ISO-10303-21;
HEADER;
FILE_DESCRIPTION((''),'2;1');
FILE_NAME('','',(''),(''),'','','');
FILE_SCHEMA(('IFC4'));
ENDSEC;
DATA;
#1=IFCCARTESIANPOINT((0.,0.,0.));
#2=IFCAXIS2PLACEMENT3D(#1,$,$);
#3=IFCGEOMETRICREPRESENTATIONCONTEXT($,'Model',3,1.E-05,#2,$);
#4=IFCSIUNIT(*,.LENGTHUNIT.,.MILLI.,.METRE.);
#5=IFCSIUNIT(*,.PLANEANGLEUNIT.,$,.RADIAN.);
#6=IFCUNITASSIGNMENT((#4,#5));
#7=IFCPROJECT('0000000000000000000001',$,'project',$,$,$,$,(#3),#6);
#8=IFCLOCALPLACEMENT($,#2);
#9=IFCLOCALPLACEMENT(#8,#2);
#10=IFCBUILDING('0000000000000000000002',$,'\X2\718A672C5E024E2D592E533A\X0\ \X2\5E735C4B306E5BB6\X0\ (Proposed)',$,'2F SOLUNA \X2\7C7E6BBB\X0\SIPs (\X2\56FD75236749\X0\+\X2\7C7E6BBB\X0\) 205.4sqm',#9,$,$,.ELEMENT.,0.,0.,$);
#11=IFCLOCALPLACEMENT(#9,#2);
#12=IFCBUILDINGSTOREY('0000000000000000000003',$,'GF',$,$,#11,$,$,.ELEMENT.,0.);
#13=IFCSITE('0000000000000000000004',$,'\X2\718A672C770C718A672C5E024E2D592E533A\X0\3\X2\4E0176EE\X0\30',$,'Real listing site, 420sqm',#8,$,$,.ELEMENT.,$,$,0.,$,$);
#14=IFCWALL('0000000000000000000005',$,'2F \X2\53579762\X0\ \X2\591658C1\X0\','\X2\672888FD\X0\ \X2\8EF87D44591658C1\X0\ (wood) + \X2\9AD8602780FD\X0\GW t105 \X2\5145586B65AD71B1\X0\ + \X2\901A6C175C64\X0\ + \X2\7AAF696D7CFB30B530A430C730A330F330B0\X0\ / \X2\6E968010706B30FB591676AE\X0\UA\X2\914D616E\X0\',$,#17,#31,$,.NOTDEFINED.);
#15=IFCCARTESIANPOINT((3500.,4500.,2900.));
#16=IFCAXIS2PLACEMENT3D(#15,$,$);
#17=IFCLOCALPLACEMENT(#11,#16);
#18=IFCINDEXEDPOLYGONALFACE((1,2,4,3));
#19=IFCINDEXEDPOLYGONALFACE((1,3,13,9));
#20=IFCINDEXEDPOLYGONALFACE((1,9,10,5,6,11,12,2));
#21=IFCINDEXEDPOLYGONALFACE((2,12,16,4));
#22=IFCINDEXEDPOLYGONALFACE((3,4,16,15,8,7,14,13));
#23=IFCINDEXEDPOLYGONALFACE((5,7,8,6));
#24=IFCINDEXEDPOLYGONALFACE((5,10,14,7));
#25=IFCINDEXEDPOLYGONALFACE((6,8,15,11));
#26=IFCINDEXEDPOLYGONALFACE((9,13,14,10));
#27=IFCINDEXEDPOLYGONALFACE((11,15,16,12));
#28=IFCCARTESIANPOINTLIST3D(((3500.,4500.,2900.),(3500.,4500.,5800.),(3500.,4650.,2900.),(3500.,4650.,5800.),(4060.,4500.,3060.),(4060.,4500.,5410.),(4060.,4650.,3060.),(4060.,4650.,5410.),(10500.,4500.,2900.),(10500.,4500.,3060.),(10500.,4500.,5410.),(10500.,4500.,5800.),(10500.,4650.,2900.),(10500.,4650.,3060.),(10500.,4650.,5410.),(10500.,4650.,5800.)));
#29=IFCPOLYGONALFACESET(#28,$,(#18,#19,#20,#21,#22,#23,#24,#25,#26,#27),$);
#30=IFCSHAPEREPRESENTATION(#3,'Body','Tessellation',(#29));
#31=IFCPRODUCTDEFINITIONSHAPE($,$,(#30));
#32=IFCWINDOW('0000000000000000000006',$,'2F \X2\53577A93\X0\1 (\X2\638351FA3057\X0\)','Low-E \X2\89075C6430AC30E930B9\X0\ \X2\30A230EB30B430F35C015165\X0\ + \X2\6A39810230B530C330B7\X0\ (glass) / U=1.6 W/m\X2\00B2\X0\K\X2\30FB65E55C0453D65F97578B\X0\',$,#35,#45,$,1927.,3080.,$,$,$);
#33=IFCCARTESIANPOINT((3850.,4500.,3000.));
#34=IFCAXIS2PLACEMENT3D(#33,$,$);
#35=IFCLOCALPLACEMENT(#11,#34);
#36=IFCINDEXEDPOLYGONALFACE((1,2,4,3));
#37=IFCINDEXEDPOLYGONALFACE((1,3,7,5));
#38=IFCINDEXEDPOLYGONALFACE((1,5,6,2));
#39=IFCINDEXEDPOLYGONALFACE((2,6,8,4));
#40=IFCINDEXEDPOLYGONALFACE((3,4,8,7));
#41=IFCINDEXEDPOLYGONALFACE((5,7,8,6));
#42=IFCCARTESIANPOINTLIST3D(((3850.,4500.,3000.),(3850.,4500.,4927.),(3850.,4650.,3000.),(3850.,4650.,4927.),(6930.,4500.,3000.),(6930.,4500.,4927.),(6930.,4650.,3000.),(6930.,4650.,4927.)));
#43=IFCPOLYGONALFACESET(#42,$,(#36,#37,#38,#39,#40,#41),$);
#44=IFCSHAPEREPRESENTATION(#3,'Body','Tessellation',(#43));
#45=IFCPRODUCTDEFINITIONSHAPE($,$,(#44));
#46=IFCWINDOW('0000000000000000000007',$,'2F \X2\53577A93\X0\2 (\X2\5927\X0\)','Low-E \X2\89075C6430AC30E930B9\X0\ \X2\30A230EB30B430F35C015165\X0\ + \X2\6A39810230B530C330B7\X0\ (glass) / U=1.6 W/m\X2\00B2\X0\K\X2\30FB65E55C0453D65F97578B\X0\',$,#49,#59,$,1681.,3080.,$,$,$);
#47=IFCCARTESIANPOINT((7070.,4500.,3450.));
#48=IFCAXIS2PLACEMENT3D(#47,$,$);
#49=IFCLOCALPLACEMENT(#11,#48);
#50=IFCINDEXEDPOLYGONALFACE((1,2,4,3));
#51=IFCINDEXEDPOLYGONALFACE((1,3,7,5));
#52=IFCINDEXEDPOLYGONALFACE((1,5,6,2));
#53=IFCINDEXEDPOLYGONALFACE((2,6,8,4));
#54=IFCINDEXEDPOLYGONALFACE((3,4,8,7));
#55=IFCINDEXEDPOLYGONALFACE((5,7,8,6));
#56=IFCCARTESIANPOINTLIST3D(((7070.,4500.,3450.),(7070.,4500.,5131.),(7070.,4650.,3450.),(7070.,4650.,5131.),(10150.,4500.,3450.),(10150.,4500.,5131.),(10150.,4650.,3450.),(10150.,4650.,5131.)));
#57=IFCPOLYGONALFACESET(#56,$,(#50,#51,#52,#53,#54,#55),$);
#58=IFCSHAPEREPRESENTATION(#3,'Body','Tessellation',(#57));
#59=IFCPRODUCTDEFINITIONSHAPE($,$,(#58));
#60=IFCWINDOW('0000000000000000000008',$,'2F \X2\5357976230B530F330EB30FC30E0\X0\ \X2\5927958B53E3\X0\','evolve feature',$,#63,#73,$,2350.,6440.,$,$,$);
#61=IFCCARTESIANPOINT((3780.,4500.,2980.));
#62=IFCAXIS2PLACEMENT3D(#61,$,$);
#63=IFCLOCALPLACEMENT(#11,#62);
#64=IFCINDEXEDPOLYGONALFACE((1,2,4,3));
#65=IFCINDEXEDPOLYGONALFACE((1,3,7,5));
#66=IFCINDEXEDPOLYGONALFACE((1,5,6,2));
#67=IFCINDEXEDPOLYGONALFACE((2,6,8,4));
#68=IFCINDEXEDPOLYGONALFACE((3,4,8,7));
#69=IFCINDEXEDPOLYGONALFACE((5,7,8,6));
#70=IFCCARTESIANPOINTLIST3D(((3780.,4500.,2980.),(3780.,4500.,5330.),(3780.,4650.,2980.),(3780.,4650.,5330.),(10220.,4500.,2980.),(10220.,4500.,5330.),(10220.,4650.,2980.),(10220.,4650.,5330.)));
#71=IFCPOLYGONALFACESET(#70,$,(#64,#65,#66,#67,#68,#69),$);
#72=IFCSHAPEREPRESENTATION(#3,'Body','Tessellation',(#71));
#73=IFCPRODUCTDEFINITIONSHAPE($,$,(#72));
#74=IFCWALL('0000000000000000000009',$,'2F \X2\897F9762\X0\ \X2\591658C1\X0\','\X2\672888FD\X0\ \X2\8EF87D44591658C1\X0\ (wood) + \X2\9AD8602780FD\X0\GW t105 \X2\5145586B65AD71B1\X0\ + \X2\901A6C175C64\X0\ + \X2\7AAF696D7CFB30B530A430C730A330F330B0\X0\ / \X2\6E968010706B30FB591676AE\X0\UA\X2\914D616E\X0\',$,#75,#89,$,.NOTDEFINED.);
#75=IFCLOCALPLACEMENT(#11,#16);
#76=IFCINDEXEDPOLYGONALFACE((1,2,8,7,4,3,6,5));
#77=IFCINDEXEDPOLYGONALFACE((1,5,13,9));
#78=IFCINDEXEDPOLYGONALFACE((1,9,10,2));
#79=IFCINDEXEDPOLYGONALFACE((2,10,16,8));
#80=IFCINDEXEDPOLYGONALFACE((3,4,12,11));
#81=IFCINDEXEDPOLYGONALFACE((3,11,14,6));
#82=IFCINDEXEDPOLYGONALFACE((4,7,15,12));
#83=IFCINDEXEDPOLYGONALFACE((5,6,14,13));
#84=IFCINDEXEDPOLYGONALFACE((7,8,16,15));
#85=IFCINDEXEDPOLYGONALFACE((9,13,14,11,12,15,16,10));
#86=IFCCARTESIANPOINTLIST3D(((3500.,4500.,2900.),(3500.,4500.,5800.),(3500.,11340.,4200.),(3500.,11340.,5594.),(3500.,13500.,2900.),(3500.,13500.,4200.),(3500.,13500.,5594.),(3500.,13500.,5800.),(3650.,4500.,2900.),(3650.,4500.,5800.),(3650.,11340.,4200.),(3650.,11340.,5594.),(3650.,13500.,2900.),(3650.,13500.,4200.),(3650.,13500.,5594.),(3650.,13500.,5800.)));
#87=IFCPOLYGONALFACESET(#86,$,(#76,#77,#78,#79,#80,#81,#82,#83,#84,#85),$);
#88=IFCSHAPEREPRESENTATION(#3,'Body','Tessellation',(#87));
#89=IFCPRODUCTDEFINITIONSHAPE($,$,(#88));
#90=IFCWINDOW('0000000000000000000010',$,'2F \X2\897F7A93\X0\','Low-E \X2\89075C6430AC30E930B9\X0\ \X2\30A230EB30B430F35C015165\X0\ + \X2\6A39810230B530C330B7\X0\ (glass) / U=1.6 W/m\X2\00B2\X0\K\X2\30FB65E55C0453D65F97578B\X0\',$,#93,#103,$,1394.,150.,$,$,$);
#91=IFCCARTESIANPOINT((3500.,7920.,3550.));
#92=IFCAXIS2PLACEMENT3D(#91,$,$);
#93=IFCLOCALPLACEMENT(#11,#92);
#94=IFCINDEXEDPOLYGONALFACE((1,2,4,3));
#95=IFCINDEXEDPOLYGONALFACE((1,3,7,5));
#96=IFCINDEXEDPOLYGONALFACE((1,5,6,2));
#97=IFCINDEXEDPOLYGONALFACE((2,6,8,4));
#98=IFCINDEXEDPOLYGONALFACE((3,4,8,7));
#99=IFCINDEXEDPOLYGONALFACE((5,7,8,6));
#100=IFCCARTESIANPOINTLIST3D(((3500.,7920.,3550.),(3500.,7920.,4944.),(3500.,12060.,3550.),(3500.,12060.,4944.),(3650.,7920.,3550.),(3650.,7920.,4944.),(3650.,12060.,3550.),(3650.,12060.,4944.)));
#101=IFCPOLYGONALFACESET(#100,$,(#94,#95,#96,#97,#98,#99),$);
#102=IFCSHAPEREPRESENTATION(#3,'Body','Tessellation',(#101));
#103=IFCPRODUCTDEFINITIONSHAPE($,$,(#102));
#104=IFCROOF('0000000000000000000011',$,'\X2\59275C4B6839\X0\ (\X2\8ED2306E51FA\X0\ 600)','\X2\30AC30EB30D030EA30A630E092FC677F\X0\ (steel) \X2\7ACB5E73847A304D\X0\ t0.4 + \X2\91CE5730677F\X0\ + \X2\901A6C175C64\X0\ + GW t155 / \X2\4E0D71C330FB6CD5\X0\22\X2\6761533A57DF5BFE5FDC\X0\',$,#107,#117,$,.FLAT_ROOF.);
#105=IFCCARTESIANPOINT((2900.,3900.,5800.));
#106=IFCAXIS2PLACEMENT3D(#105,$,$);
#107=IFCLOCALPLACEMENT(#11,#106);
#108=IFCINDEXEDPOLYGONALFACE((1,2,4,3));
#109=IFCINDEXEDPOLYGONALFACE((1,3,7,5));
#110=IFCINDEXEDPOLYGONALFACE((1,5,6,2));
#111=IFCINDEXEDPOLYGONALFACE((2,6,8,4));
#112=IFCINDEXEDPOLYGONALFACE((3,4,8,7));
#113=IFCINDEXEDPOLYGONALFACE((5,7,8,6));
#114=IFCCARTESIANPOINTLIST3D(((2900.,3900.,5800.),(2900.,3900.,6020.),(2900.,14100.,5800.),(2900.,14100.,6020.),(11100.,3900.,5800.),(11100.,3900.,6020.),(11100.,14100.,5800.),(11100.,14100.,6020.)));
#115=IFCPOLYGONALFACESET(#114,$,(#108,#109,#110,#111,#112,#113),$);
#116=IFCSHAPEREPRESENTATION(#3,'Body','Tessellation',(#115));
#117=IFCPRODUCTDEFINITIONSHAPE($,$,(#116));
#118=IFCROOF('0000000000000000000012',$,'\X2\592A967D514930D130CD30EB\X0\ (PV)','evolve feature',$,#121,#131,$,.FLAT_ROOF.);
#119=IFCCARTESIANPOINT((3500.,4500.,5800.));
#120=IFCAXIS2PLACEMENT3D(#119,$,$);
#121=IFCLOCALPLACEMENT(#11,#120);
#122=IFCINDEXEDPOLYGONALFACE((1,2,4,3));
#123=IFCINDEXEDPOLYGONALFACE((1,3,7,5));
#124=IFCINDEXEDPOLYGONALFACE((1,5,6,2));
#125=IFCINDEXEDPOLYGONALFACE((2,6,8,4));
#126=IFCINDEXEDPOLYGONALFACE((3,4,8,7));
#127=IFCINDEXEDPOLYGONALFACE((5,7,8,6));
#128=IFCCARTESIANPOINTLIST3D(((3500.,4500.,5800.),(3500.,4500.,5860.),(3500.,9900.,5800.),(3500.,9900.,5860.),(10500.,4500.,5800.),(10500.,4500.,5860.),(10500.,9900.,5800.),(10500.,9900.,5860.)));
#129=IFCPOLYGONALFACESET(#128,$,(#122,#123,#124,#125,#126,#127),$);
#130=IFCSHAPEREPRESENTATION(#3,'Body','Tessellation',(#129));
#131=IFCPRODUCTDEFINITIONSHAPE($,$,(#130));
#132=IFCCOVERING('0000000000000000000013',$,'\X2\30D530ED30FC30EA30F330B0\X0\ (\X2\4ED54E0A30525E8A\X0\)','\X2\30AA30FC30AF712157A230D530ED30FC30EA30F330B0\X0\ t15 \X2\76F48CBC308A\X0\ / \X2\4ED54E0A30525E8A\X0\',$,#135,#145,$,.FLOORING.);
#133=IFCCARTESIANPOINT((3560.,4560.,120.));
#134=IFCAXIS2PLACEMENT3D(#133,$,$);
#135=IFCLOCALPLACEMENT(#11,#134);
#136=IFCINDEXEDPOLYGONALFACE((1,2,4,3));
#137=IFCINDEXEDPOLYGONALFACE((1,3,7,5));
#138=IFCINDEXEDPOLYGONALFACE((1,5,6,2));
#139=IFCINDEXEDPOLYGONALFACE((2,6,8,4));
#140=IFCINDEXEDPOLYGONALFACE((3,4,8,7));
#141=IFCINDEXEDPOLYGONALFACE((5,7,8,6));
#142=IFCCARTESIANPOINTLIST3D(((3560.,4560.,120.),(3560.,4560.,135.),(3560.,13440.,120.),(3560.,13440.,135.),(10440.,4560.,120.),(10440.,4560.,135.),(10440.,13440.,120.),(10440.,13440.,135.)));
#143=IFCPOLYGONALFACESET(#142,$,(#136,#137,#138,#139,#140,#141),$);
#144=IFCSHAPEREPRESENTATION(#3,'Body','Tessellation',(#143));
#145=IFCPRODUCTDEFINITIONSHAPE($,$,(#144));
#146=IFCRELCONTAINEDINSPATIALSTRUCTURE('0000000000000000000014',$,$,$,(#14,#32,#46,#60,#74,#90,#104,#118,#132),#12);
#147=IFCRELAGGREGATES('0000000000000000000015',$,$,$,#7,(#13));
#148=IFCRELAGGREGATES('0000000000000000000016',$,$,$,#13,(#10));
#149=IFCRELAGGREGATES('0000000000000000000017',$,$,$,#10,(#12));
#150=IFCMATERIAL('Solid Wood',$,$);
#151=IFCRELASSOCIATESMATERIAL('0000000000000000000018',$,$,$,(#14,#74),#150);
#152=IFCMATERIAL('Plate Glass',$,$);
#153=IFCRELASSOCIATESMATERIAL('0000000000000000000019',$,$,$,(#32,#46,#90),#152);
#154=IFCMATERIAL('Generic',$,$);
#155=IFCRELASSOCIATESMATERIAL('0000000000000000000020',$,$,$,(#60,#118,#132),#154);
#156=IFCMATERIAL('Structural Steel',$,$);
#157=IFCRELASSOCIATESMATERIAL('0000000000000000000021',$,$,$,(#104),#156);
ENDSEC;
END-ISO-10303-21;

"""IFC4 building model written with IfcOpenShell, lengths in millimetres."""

from ifc_helpers import new_model, si_unit, frame, frame_2d, origin, place, context, project, spatial, rectangle, extrude, material, element, fill, save


model = new_model("IFC4")

# Units and contexts
model_context = context("Model", 3, precision=1e-05, world=origin())
ifc_project = project(units=[si_unit("LENGTHUNIT", "METRE", prefix="MILLI"), si_unit("PLANEANGLEUNIT", "RADIAN")], contexts=[model_context])

# Site, building, storey
site_placement = place(None, origin())
site = spatial("IfcSite", under=ifc_project, at=site_placement, Name="熊本県熊本市中央区3丁目30", ObjectType="Real listing site, 420sqm", CompositionType="ELEMENT", RefElevation=0.0)
building_placement = place(site_placement, origin())
building = spatial("IfcBuilding", under=site, at=building_placement, Name="熊本市中央区 平屋の家 (Proposed)", ObjectType="2F SOLUNA 籾殻SIPs (国産杉+籾殻) 205.4sqm", CompositionType="ELEMENT", ElevationOfRefHeight=0.0, ElevationOfTerrain=0.0)
storey_placement = place(building_placement, origin())
storey = spatial("IfcBuildingStorey", under=building, at=storey_placement, Name="GF", CompositionType="ELEMENT", Elevation=0.0)

# Shared definitions
ifc_material_1 = material(Name="Solid Wood")

# Shared definitions
ifc_material_2 = material(Name="Plate Glass")
ifc_material_3 = material(Name="Generic")

# Wall, openings, windows
wall_1_placement = place(storey_placement, frame((3500.0, 4500.0, 2900.0)))
wall_1 = element("IfcWall", 1, at=wall_1_placement, inside=storey, material=ifc_material_1, Name="2F 南面 外壁", Description="木製 軸組外壁 (wood) + 高性能GW t105 充填断熱 + 通気層 + 窯業系サイディング / 準耐火・外皮UA配慮", PredefinedType="NOTDEFINED", context=model_context, shape_type="SweptSolid", body=[
    extrude(rectangle(XDim=7000.0, YDim=150.0, at=frame_2d((3500.0, 75.0))), frame((3500.0, 4500.0, 2900.0)), (0.0, 0.0, 1.0), 2900.0),
])
opening_1_placement = place(storey_placement, frame((3850.0, 4500.0, 3000.0)))
opening_1 = element("IfcOpeningElement", 2, at=opening_1_placement, cuts=wall_1, PredefinedType="NOTDEFINED", context=model_context, shape_type="SweptSolid", body=[
    extrude(rectangle(XDim=3080.0, YDim=150.0, at=frame_2d((1540.0, 75.0))), frame((3850.0, 4500.0, 3000.0)), (0.0, 0.0, 1.0), 1927.0),
])
opening_2_placement = place(storey_placement, frame((7070.0, 4500.0, 3450.0)))
opening_2 = element("IfcOpeningElement", 3, at=opening_2_placement, cuts=wall_1, PredefinedType="NOTDEFINED", context=model_context, shape_type="SweptSolid", body=[
    extrude(rectangle(XDim=3080.0, YDim=150.0, at=frame_2d((1540.0, 75.0))), frame((7070.0, 4500.0, 3450.0)), (0.0, 0.0, 1.0), 1681.0),
])
opening_3_placement = place(storey_placement, frame((3780.0, 4500.0, 2980.0)))
opening_3 = element("IfcOpeningElement", 4, at=opening_3_placement, cuts=wall_1, PredefinedType="NOTDEFINED", context=model_context, shape_type="SweptSolid", body=[
    extrude(rectangle(XDim=6440.0, YDim=150.0, at=frame_2d((3220.0, 75.0))), frame((3780.0, 4500.0, 2980.0)), (0.0, 0.0, 1.0), 2350.0),
])
window_1_placement = place(storey_placement, frame((3850.0, 4500.0, 3000.0)))
window_1 = element("IfcWindow", 5, at=window_1_placement, inside=storey, material=ifc_material_2, Name="2F 南窓1 (掃出し)", Description="Low-E 複層ガラス アルゴン封入 + 樹脂サッシ (glass) / U=1.6 W/m²K・日射取得型", OverallHeight=1927.0, OverallWidth=3080.0, context=model_context, shape_type="SweptSolid", body=[
    extrude(rectangle(XDim=3080.0, YDim=150.0, at=frame_2d((1540.0, 75.0))), frame((3850.0, 4500.0, 3000.0)), (0.0, 0.0, 1.0), 1927.0),
])
fill(opening_1, window_1)
window_2_placement = place(storey_placement, frame((7070.0, 4500.0, 3450.0)))
window_2 = element("IfcWindow", 6, at=window_2_placement, inside=storey, material=ifc_material_2, Name="2F 南窓2 (大)", Description="Low-E 複層ガラス アルゴン封入 + 樹脂サッシ (glass) / U=1.6 W/m²K・日射取得型", OverallHeight=1681.0, OverallWidth=3080.0, context=model_context, shape_type="SweptSolid", body=[
    extrude(rectangle(XDim=3080.0, YDim=150.0, at=frame_2d((1540.0, 75.0))), frame((7070.0, 4500.0, 3450.0)), (0.0, 0.0, 1.0), 1681.0),
])
fill(opening_2, window_2)
window_3_placement = place(storey_placement, frame((3780.0, 4500.0, 2980.0)))
window_3 = element("IfcWindow", 7, at=window_3_placement, inside=storey, material=ifc_material_3, Name="2F 南面サンルーム 大開口", Description="evolve feature", OverallHeight=2350.0, OverallWidth=6440.0, context=model_context, shape_type="SweptSolid", body=[
    extrude(rectangle(XDim=6440.0, YDim=150.0, at=frame_2d((3220.0, 75.0))), frame((3780.0, 4500.0, 2980.0)), (0.0, 0.0, 1.0), 2350.0),
])
fill(opening_3, window_3)

# Wall, opening, window
wall_2_placement = place(storey_placement, frame((3500.0, 4500.0, 2900.0)))
wall_2 = element("IfcWall", 8, at=wall_2_placement, inside=storey, material=ifc_material_1, Name="2F 西面 外壁", Description="木製 軸組外壁 (wood) + 高性能GW t105 充填断熱 + 通気層 + 窯業系サイディング / 準耐火・外皮UA配慮", PredefinedType="NOTDEFINED", context=model_context, shape_type="SweptSolid", body=[
    extrude(rectangle(XDim=150.0, YDim=9000.0, at=frame_2d((75.0, 4500.0))), frame((3500.0, 4500.0, 2900.0)), (0.0, 0.0, 1.0), 2900.0),
])
opening_4_placement = place(storey_placement, frame((3500.0, 7920.0, 3550.0)))
opening_4 = element("IfcOpeningElement", 9, at=opening_4_placement, cuts=wall_2, PredefinedType="NOTDEFINED", context=model_context, shape_type="SweptSolid", body=[
    extrude(rectangle(XDim=150.0, YDim=4140.0, at=frame_2d((75.0, 2070.0))), frame((3500.0, 7920.0, 3550.0)), (0.0, 0.0, 1.0), 1394.0),
])
window_4_placement = place(storey_placement, frame((3500.0, 7920.0, 3550.0)))
window_4 = element("IfcWindow", 10, at=window_4_placement, inside=storey, material=ifc_material_2, Name="2F 西窓", Description="Low-E 複層ガラス アルゴン封入 + 樹脂サッシ (glass) / U=1.6 W/m²K・日射取得型", OverallHeight=1394.0, OverallWidth=150.0, context=model_context, shape_type="SweptSolid", body=[
    extrude(rectangle(XDim=150.0, YDim=4140.0, at=frame_2d((75.0, 2070.0))), frame((3500.0, 7920.0, 3550.0)), (0.0, 0.0, 1.0), 1394.0),
])
fill(opening_4, window_4)

# Roofs
ifc_material_4 = material(Name="Structural Steel")
roof_1_placement = place(storey_placement, frame((2900.0, 3900.0, 5800.0)))
element("IfcRoof", 11, at=roof_1_placement, inside=storey, material=ifc_material_4, Name="大屋根 (軒の出 600)", Description="ガルバリウム鋼板 (steel) 立平葺き t0.4 + 野地板 + 通気層 + GW t155 / 不燃・法22条区域対応", PredefinedType="FLAT_ROOF", context=model_context, shape_type="SweptSolid", body=[
    extrude(rectangle(XDim=8200.0, YDim=10200.0, at=frame_2d((4100.0, 5100.0))), frame((2900.0, 3900.0, 5800.0)), (0.0, 0.0, 1.0), 220.0),
])
roof_2_placement = place(storey_placement, frame((3500.0, 4500.0, 5800.0)))
element("IfcRoof", 12, at=roof_2_placement, inside=storey, material=ifc_material_3, Name="太陽光パネル (PV)", Description="evolve feature", PredefinedType="FLAT_ROOF", context=model_context, shape_type="SweptSolid", body=[
    extrude(rectangle(XDim=7000.0, YDim=5400.0, at=frame_2d((3500.0, 2700.0))), frame((3500.0, 4500.0, 5800.0)), (0.0, 0.0, 1.0), 60.0),
])

# Covering
covering_placement = place(storey_placement, frame((3560.0, 4560.0, 120.0)))
element("IfcCovering", 13, at=covering_placement, inside=storey, material=ifc_material_3, Name="フローリング (仕上げ床)", Description="オーク無垢フローリング t15 直貼り / 仕上げ床", PredefinedType="FLOORING", context=model_context, shape_type="SweptSolid", body=[
    extrude(rectangle(XDim=6880.0, YDim=8880.0, at=frame_2d((3440.0, 4440.0))), frame((3560.0, 4560.0, 120.0)), (0.0, 0.0, 1.0), 15.0),
])

save(model, "model.ifc")
